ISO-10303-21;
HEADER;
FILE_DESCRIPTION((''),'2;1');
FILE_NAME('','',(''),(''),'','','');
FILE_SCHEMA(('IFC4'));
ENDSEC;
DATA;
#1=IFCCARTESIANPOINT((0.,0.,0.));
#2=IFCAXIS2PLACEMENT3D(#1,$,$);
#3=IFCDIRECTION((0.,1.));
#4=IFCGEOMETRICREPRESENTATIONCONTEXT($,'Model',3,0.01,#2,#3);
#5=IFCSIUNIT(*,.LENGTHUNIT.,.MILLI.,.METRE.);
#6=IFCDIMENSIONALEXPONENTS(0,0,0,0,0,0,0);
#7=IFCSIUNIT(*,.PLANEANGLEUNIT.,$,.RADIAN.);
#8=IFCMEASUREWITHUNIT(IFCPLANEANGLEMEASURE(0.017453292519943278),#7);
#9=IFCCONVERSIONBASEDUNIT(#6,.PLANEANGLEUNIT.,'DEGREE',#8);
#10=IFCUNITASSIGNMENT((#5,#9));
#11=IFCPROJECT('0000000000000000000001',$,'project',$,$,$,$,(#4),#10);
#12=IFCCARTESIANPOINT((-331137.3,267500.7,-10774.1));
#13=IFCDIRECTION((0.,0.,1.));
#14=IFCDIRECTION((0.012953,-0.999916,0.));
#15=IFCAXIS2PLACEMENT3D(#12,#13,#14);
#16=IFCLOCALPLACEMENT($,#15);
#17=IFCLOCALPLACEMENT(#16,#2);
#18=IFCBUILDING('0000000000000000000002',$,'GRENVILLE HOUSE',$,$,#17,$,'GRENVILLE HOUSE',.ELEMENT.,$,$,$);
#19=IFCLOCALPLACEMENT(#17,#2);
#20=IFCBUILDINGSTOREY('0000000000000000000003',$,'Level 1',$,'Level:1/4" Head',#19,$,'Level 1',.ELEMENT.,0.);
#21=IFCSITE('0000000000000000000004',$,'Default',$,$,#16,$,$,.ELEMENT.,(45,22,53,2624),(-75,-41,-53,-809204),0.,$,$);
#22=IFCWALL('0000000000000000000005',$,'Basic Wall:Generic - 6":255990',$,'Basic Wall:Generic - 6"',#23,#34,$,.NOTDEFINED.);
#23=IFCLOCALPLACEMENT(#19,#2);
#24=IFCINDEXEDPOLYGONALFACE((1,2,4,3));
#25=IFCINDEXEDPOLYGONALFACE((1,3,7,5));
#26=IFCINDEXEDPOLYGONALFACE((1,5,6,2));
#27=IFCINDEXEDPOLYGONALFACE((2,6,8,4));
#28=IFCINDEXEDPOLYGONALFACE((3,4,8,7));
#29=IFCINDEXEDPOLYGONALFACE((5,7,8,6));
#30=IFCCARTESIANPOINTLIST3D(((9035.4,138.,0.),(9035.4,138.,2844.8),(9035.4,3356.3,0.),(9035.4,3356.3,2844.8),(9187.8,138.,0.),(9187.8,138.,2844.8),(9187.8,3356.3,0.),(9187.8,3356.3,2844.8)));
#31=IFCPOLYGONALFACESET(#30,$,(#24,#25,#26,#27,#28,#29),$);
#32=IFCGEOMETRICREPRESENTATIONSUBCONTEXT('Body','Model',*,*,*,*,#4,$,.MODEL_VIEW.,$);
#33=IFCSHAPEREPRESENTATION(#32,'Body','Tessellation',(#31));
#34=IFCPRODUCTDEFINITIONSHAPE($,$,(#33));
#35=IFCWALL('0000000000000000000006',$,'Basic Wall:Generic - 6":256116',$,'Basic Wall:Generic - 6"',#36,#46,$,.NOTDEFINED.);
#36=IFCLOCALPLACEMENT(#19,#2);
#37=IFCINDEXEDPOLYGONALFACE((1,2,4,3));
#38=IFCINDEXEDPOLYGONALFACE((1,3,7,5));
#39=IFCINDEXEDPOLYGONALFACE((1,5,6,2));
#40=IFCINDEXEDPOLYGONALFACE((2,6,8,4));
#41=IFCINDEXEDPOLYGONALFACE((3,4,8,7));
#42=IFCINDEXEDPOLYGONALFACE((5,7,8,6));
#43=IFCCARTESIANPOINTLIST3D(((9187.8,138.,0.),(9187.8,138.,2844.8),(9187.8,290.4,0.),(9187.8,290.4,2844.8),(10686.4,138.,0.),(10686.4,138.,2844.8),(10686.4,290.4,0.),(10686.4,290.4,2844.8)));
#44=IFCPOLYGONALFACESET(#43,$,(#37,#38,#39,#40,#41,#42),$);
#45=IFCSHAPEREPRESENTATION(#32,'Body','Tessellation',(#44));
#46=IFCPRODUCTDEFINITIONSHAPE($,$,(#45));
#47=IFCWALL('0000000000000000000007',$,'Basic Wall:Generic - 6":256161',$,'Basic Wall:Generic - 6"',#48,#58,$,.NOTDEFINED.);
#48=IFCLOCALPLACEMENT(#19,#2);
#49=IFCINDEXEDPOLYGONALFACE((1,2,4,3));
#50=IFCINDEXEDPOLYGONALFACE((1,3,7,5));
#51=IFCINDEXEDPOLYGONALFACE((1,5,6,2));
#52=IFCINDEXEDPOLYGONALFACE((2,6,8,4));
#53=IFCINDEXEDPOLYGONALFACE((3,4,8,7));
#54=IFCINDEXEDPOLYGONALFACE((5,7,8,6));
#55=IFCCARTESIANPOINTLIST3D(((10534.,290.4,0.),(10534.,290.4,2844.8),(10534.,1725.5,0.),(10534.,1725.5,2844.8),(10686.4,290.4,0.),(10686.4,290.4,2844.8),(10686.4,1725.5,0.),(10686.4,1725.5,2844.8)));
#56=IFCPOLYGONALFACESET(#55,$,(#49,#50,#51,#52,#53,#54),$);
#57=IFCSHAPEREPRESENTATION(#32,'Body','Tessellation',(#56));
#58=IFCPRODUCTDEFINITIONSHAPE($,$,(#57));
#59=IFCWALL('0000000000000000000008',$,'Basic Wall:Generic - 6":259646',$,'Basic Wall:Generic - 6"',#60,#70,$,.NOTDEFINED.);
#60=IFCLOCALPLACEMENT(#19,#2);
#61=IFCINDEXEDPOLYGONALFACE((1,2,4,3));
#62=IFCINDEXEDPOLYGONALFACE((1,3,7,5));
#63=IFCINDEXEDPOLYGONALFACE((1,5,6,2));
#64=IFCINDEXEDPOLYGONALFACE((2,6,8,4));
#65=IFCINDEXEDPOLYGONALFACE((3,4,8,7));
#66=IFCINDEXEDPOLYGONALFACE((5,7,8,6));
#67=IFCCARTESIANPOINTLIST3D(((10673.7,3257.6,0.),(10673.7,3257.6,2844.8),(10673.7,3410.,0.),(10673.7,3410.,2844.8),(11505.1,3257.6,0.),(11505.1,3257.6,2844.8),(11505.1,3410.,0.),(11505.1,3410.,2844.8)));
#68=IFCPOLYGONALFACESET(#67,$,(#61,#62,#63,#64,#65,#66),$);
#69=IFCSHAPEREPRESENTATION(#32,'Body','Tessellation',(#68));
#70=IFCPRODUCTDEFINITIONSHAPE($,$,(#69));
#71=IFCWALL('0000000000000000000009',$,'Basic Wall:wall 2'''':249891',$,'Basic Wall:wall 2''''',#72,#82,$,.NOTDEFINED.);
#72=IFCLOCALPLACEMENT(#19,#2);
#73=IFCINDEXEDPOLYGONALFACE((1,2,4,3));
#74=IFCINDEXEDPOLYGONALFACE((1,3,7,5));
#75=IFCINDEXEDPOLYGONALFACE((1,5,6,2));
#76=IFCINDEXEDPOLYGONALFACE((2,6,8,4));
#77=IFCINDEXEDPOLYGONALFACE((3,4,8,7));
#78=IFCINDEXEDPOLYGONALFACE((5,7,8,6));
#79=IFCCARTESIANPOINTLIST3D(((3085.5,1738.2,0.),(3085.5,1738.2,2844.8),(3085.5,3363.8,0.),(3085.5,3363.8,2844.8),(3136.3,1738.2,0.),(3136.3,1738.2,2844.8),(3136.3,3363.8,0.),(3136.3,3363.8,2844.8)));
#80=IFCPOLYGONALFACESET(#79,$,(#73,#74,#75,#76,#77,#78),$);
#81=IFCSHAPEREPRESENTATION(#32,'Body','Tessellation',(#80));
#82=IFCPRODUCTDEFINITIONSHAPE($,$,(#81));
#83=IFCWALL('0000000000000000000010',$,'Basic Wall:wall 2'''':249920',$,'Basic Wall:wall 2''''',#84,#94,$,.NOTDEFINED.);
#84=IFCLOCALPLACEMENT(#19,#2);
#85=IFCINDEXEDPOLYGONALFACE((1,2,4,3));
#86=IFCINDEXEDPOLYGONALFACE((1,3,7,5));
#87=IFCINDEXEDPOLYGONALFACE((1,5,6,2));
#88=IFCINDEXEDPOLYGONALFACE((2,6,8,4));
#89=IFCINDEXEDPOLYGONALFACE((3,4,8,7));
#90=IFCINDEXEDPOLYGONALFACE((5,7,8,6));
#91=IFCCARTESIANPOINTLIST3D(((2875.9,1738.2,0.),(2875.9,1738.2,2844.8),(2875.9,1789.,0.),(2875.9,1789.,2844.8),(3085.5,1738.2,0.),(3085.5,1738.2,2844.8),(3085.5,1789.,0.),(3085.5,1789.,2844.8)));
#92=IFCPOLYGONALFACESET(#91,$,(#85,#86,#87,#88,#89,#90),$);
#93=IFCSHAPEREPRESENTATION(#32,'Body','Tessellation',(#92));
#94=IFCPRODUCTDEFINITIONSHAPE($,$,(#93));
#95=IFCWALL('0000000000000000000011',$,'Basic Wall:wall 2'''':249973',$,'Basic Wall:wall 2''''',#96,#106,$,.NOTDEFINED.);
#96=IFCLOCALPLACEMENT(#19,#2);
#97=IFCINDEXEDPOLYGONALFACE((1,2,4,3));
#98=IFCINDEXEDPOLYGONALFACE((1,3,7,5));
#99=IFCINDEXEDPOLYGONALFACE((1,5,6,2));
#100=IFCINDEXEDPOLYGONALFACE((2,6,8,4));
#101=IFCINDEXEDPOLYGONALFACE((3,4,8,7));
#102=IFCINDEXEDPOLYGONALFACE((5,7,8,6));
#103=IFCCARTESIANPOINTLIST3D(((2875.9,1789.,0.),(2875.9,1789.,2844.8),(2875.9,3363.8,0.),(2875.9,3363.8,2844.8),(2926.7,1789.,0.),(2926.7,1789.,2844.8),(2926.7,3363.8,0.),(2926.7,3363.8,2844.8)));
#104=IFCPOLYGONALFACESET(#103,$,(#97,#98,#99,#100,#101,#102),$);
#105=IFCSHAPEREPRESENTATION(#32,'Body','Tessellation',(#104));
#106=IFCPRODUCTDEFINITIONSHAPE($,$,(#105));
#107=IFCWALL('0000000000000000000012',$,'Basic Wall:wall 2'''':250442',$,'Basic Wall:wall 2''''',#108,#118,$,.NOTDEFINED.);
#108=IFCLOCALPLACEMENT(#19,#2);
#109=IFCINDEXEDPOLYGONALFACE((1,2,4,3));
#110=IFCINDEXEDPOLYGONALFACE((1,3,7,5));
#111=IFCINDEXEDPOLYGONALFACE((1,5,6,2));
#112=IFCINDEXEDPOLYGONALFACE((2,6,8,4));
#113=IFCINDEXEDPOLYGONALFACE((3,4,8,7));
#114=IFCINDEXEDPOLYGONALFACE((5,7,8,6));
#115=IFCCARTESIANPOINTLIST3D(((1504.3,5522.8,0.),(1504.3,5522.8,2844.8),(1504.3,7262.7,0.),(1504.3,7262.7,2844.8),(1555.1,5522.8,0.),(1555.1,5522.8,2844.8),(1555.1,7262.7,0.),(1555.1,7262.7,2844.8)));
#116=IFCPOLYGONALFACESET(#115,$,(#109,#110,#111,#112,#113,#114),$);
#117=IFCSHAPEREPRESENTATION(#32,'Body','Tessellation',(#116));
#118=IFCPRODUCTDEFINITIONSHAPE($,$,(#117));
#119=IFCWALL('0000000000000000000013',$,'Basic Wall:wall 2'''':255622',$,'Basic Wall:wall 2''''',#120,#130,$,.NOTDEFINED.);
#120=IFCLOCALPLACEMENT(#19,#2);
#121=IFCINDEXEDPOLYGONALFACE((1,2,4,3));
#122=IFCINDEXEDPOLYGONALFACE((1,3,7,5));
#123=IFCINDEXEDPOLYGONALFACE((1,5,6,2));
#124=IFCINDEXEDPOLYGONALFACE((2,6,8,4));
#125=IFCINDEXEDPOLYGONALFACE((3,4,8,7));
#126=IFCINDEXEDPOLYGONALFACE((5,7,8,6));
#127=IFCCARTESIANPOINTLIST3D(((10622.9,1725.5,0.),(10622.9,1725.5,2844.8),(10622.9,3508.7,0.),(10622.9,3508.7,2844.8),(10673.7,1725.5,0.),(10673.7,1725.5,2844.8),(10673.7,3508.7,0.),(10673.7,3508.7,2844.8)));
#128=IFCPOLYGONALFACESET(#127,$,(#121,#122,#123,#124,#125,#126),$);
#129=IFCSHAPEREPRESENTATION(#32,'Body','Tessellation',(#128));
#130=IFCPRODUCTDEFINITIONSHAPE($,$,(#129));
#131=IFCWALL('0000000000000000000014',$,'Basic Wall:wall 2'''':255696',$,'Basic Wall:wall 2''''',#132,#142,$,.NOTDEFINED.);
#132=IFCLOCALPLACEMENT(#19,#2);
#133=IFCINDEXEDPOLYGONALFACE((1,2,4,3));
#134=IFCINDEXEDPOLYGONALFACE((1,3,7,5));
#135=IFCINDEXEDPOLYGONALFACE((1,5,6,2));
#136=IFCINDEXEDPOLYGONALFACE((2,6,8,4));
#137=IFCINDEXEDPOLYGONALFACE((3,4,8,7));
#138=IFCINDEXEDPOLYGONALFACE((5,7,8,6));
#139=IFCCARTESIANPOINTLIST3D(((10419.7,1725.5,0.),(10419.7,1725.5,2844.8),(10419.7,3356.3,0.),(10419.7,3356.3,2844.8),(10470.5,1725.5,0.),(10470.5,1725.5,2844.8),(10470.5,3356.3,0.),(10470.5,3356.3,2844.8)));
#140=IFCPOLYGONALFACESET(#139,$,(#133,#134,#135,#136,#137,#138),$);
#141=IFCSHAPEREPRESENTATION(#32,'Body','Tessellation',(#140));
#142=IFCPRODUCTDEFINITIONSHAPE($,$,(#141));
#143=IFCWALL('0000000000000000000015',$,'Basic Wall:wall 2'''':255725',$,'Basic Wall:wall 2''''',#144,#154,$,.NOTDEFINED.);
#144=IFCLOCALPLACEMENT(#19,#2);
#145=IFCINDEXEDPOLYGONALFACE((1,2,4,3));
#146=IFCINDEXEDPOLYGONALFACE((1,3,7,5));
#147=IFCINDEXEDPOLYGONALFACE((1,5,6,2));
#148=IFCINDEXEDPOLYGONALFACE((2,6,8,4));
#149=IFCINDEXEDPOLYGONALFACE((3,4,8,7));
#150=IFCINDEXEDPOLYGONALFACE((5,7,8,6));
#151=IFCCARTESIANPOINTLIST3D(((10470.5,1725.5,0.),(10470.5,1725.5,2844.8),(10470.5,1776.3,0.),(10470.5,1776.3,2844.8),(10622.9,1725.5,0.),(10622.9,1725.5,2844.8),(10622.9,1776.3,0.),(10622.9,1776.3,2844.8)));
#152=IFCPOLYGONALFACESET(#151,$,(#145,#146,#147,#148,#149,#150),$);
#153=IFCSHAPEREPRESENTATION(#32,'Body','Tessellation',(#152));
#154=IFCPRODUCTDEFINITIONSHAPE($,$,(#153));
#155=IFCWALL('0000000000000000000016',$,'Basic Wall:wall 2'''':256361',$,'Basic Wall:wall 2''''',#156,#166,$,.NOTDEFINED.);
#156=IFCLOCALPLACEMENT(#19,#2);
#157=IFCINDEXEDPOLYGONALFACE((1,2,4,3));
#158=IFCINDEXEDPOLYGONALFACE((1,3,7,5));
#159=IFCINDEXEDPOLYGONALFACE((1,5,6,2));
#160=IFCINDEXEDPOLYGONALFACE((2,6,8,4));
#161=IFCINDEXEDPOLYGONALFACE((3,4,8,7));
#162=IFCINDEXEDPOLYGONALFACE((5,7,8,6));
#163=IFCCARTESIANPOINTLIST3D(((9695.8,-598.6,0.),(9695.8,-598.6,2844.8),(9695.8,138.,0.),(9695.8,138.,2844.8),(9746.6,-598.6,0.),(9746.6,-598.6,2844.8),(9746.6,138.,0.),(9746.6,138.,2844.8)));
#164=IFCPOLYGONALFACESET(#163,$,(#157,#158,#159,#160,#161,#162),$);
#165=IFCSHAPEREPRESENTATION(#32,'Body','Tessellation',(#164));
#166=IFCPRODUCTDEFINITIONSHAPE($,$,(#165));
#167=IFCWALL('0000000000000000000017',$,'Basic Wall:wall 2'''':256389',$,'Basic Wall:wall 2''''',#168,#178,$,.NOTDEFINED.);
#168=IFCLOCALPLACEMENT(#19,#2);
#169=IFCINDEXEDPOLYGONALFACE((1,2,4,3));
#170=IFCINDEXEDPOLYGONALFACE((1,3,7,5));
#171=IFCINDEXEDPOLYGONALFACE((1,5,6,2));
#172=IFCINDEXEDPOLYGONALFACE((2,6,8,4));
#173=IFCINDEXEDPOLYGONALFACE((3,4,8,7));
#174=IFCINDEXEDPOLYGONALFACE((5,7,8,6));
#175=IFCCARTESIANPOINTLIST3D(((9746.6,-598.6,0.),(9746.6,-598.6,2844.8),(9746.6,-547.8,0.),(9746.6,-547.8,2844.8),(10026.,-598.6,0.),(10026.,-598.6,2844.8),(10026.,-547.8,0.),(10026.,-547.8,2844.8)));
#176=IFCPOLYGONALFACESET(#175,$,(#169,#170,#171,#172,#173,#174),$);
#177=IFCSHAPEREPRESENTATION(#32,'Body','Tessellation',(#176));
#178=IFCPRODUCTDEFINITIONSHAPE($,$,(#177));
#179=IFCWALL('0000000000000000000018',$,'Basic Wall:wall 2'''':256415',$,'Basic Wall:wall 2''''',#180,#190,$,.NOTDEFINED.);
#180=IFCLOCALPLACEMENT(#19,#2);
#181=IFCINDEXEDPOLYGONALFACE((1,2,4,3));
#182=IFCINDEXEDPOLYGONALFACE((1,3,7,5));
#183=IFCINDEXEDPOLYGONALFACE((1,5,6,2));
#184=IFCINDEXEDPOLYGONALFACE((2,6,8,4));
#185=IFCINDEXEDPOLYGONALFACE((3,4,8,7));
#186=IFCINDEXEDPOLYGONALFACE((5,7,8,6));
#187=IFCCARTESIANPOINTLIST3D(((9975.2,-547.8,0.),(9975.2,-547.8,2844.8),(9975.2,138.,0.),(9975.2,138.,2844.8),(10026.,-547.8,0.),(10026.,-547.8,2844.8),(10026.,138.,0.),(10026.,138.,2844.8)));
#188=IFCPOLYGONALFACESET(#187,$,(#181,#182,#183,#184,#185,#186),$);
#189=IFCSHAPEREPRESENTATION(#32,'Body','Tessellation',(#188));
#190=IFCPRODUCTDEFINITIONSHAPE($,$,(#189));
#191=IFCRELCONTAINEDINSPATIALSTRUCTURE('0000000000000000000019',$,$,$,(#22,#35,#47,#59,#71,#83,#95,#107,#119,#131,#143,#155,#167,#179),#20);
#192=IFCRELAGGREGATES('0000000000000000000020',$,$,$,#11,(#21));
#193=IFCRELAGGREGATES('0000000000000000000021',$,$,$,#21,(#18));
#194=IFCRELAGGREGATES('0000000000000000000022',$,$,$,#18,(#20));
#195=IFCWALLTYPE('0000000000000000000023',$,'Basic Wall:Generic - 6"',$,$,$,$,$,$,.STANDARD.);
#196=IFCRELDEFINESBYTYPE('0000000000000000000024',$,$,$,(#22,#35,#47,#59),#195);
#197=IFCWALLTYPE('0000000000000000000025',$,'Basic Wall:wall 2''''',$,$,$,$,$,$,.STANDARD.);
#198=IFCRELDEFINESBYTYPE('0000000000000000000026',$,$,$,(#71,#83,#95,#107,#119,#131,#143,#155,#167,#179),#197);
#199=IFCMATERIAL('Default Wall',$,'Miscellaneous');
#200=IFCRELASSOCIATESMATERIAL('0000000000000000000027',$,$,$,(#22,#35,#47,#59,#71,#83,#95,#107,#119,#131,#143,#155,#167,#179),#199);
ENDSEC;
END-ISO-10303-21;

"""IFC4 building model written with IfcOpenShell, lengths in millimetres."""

from ifc_helpers import new_model, entity, si_unit, converted_unit, direction, frame, origin, place, context, subcontext, project, spatial, indexed_curve, outline, extrude, material, type_object, element, save


model = new_model("IFC4")

# Units and contexts
model_context = context("Model", 3, precision=0.01, world=origin(), true_north=direction((0.0, 1.0)))
body_context = subcontext(model_context, "Body", "Model", "MODEL_VIEW")
ifc_project = project(units=[si_unit("LENGTHUNIT", "METRE", prefix="MILLI"), converted_unit("PLANEANGLEUNIT", "DEGREE", entity("IfcPlaneAngleMeasure", 0.017453292519943278), si_unit("PLANEANGLEUNIT", "RADIAN"), dimensions=[0, 0, 0, 0, 0, 0, 0])], contexts=[model_context])

# Site, building, storey
site_placement = place(None, frame((-331137.3, 267500.7, -10774.1), z_axis=(0.0, 0.0, 1.0), x_axis=(0.012953, -0.999916, 0.0)))
site = spatial("IfcSite", under=ifc_project, at=site_placement, Name="Default", CompositionType="ELEMENT", RefLatitude=(45, 22, 53, 2624), RefLongitude=(-75, -41, -53, -809204), RefElevation=0.0)
building_placement = place(site_placement, origin())
building = spatial("IfcBuilding", under=site, at=building_placement, Name="GRENVILLE HOUSE", LongName="GRENVILLE HOUSE", CompositionType="ELEMENT")
storey_placement = place(building_placement, origin())
storey = spatial("IfcBuildingStorey", under=building, at=storey_placement, Name="Level 1", ObjectType="Level:1/4\" Head", LongName="Level 1", CompositionType="ELEMENT", Elevation=0.0)

# Walls
ifc_material_1 = material(Name="Default Wall", Category="Miscellaneous")
wall_type_1 = type_object("IfcWallType", Name="Basic Wall:Generic - 6\"", PredefinedType="STANDARD")
wall_1_placement = place(storey_placement, frame((9111.6, 138.0, 0.0), z_axis=(0.0, 0.0, 1.0), x_axis=(0.0, 1.0, 0.0)))
element("IfcWall", 1, at=wall_1_placement, inside=storey, type_object=wall_type_1, material=ifc_material_1, Name="Basic Wall:Generic - 6\":255990", ObjectType="Basic Wall:Generic - 6\"", PredefinedType="NOTDEFINED", context=body_context, shape_type="SweptSolid", body=[
    extrude(outline(indexed_curve([(3218.2, 76.2), (0.0, 76.2), (0.0, -76.2), (3218.2, -76.2), (3218.2, 76.2)], self_intersect=False)), origin(), (0.0, 0.0, 1.0), 2844.8),
])
wall_2_placement = place(storey_placement, frame((9187.8, 214.2, 0.0)))
element("IfcWall", 2, at=wall_2_placement, inside=storey, type_object=wall_type_1, material=ifc_material_1, Name="Basic Wall:Generic - 6\":256116", ObjectType="Basic Wall:Generic - 6\"", PredefinedType="NOTDEFINED", context=body_context, shape_type="SweptSolid", body=[
    extrude(outline(indexed_curve([(1498.6, 76.2), (0.0, 76.2), (0.0, -76.2), (1498.6, -76.2), (1498.6, 76.2)], self_intersect=False)), origin(), (0.0, 0.0, 1.0), 2844.8),
])
wall_3_placement = place(storey_placement, frame((10610.2, 290.4, 0.0), z_axis=(0.0, 0.0, 1.0), x_axis=(0.0, 1.0, 0.0)))
element("IfcWall", 3, at=wall_3_placement, inside=storey, type_object=wall_type_1, material=ifc_material_1, Name="Basic Wall:Generic - 6\":256161", ObjectType="Basic Wall:Generic - 6\"", PredefinedType="NOTDEFINED", context=body_context, shape_type="SweptSolid", body=[
    extrude(outline(indexed_curve([(1435.1, 76.2), (0.0, 76.2), (0.0, -76.2), (1435.1, -76.2), (1435.1, 76.2)], self_intersect=False)), origin(), (0.0, 0.0, 1.0), 2844.8),
])
wall_4_placement = place(storey_placement, frame((11505.1, 3333.8, 0.0), z_axis=(0.0, 0.0, 1.0), x_axis=(-1.0, 0.0, 0.0)))
element("IfcWall", 4, at=wall_4_placement, inside=storey, type_object=wall_type_1, material=ifc_material_1, Name="Basic Wall:Generic - 6\":259646", ObjectType="Basic Wall:Generic - 6\"", PredefinedType="NOTDEFINED", context=body_context, shape_type="SweptSolid", body=[
    extrude(outline(indexed_curve([(831.3, 76.2), (0.0, 76.2), (0.0, -76.2), (831.3, -76.2), (831.3, 76.2)], self_intersect=False)), origin(), (0.0, 0.0, 1.0), 2844.8),
])
wall_type_2 = type_object("IfcWallType", Name="Basic Wall:wall 2''", PredefinedType="STANDARD")
wall_5_placement = place(storey_placement, frame((3110.9, 3363.8, 0.0), z_axis=(0.0, 0.0, 1.0), x_axis=(0.0, -1.0, 0.0)))
element("IfcWall", 5, at=wall_5_placement, inside=storey, type_object=wall_type_2, material=ifc_material_1, Name="Basic Wall:wall 2'':249891", ObjectType="Basic Wall:wall 2''", PredefinedType="NOTDEFINED", context=body_context, shape_type="SweptSolid", body=[
    extrude(outline(indexed_curve([(1625.6, 25.4), (0.0, 25.4), (0.0, -25.4), (1625.6, -25.4), (1625.6, 25.4)], self_intersect=False)), origin(), (0.0, 0.0, 1.0), 2844.8),
])
wall_6_placement = place(storey_placement, frame((3085.5, 1763.6, 0.0), z_axis=(0.0, 0.0, 1.0), x_axis=(-1.0, 0.0, 0.0)))
element("IfcWall", 6, at=wall_6_placement, inside=storey, type_object=wall_type_2, material=ifc_material_1, Name="Basic Wall:wall 2'':249920", ObjectType="Basic Wall:wall 2''", PredefinedType="NOTDEFINED", context=body_context, shape_type="SweptSolid", body=[
    extrude(outline(indexed_curve([(209.6, 25.4), (0.0, 25.4), (0.0, -25.4), (209.6, -25.4), (209.6, 25.4)], self_intersect=False)), origin(), (0.0, 0.0, 1.0), 2844.8),
])
wall_7_placement = place(storey_placement, frame((2901.3, 1789.0, 0.0), z_axis=(0.0, 0.0, 1.0), x_axis=(0.0, 1.0, 0.0)))
element("IfcWall", 7, at=wall_7_placement, inside=storey, type_object=wall_type_2, material=ifc_material_1, Name="Basic Wall:wall 2'':249973", ObjectType="Basic Wall:wall 2''", PredefinedType="NOTDEFINED", context=body_context, shape_type="SweptSolid", body=[
    extrude(outline(indexed_curve([(1574.8, 25.4), (0.0, 25.4), (0.0, -25.4), (1574.8, -25.4), (1574.8, 25.4)], self_intersect=False)), origin(), (0.0, 0.0, 1.0), 2844.8),
])
wall_8_placement = place(storey_placement, frame((1529.7, 5522.8, 0.0), z_axis=(0.0, 0.0, 1.0), x_axis=(0.0, 1.0, 0.0)))
element("IfcWall", 8, at=wall_8_placement, inside=storey, type_object=wall_type_2, material=ifc_material_1, Name="Basic Wall:wall 2'':250442", ObjectType="Basic Wall:wall 2''", PredefinedType="NOTDEFINED", context=body_context, shape_type="SweptSolid", body=[
    extrude(outline(indexed_curve([(1739.9, 25.4), (0.0, 25.4), (0.0, -25.4), (1739.9, -25.4), (1739.9, 25.4)], self_intersect=False)), origin(), (0.0, 0.0, 1.0), 2844.8),
])
wall_9_placement = place(storey_placement, frame((10648.3, 1725.5, 0.0), z_axis=(0.0, 0.0, 1.0), x_axis=(0.0, 1.0, 0.0)))
element("IfcWall", 9, at=wall_9_placement, inside=storey, type_object=wall_type_2, material=ifc_material_1, Name="Basic Wall:wall 2'':255622", ObjectType="Basic Wall:wall 2''", PredefinedType="NOTDEFINED", context=body_context, shape_type="SweptSolid", body=[
    extrude(outline(indexed_curve([(1783.1, 25.4), (0.0, 25.4), (0.0, -25.4), (1783.1, -25.4), (1783.1, 25.4)], self_intersect=False)), origin(), (0.0, 0.0, 1.0), 2844.8),
])
wall_10_placement = place(storey_placement, frame((10445.1, 3356.3, 0.0), z_axis=(0.0, 0.0, 1.0), x_axis=(0.0, -1.0, 0.0)))
element("IfcWall", 10, at=wall_10_placement, inside=storey, type_object=wall_type_2, material=ifc_material_1, Name="Basic Wall:wall 2'':255696", ObjectType="Basic Wall:wall 2''", PredefinedType="NOTDEFINED", context=body_context, shape_type="SweptSolid", body=[
    extrude(outline(indexed_curve([(1630.7, 25.4), (0.0, 25.4), (0.0, -25.4), (1630.7, -25.4), (1630.7, 25.4)], self_intersect=False)), origin(), (0.0, 0.0, 1.0), 2844.8),
])
wall_11_placement = place(storey_placement, frame((10470.5, 1750.9, 0.0)))
element("IfcWall", 11, at=wall_11_placement, inside=storey, type_object=wall_type_2, material=ifc_material_1, Name="Basic Wall:wall 2'':255725", ObjectType="Basic Wall:wall 2''", PredefinedType="NOTDEFINED", context=body_context, shape_type="SweptSolid", body=[
    extrude(outline(indexed_curve([(152.4, 25.4), (0.0, 25.4), (0.0, -25.4), (152.4, -25.4), (152.4, 25.4)], self_intersect=False)), origin(), (0.0, 0.0, 1.0), 2844.8),
])
wall_12_placement = place(storey_placement, frame((9721.2, 138.0, 0.0), z_axis=(0.0, 0.0, 1.0), x_axis=(0.0, -1.0, 0.0)))
element("IfcWall", 12, at=wall_12_placement, inside=storey, type_object=wall_type_2, material=ifc_material_1, Name="Basic Wall:wall 2'':256361", ObjectType="Basic Wall:wall 2''", PredefinedType="NOTDEFINED", context=body_context, shape_type="SweptSolid", body=[
    extrude(outline(indexed_curve([(736.6, 25.4), (0.0, 25.4), (0.0, -25.4), (736.6, -25.4), (736.6, 25.4)], self_intersect=False)), origin(), (0.0, 0.0, 1.0), 2844.8),
])
wall_13_placement = place(storey_placement, frame((9746.6, -573.2, 0.0)))
element("IfcWall", 13, at=wall_13_placement, inside=storey, type_object=wall_type_2, material=ifc_material_1, Name="Basic Wall:wall 2'':256389", ObjectType="Basic Wall:wall 2''", PredefinedType="NOTDEFINED", context=body_context, shape_type="SweptSolid", body=[
    extrude(outline(indexed_curve([(279.4, 25.4), (0.0, 25.4), (0.0, -25.4), (279.4, -25.4), (279.4, 25.4)], self_intersect=False)), origin(), (0.0, 0.0, 1.0), 2844.8),
])
wall_14_placement = place(storey_placement, frame((10000.6, -547.8, 0.0), z_axis=(0.0, 0.0, 1.0), x_axis=(0.0, 1.0, 0.0)))
element("IfcWall", 14, at=wall_14_placement, inside=storey, type_object=wall_type_2, material=ifc_material_1, Name="Basic Wall:wall 2'':256415", ObjectType="Basic Wall:wall 2''", PredefinedType="NOTDEFINED", context=body_context, shape_type="SweptSolid", body=[
    extrude(outline(indexed_curve([(685.8, 25.4), (0.0, 25.4), (0.0, -25.4), (685.8, -25.4), (685.8, 25.4)], self_intersect=False)), origin(), (0.0, 0.0, 1.0), 2844.8),
])

save(model, "model.ifc")
